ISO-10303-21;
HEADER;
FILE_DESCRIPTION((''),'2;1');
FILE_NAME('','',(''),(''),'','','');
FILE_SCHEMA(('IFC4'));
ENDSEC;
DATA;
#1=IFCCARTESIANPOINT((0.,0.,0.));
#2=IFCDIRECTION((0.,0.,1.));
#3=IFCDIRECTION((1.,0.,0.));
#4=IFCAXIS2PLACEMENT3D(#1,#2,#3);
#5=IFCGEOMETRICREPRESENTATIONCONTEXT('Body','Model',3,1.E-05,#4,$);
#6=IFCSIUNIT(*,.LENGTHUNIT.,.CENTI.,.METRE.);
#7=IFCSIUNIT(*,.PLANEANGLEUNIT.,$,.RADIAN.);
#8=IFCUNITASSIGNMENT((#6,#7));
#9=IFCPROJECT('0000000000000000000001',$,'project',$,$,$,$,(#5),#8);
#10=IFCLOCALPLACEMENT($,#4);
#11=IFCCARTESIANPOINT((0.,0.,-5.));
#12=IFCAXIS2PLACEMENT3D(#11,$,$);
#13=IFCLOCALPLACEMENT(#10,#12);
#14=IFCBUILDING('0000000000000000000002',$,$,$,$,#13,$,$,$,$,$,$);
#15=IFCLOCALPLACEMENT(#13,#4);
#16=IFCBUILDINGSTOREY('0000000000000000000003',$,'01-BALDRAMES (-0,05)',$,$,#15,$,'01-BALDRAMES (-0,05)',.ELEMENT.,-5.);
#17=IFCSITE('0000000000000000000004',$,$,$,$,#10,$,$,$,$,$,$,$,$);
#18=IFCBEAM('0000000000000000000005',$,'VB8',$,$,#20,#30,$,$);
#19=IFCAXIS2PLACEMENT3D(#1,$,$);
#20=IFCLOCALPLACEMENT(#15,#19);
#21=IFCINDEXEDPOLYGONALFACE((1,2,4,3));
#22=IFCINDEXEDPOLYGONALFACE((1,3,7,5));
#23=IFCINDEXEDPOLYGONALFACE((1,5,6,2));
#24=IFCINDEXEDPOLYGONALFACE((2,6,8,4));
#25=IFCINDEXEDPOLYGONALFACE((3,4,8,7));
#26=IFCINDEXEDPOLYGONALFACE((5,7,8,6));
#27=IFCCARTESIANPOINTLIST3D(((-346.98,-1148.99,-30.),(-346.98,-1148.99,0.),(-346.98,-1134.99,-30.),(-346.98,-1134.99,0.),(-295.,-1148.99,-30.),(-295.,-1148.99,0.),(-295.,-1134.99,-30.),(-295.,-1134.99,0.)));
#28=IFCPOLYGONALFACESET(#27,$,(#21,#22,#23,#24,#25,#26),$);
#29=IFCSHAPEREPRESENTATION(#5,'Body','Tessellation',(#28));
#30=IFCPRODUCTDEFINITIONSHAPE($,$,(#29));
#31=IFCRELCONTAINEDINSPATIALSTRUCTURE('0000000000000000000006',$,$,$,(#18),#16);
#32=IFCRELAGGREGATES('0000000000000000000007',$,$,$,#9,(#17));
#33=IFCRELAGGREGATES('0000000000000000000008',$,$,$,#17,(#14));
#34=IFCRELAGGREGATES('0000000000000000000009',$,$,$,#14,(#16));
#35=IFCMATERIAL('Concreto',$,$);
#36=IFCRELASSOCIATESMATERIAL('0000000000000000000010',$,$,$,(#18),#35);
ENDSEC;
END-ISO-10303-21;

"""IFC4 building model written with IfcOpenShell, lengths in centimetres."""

from ifc_helpers import new_model, si_unit, frame, origin_with_axes, origin_2d_with_axis, place, context, project, spatial, rectangle, extrude, material, element, save


model = new_model("IFC4")

# Units and contexts
model_context = context("Model", 3, precision=1e-05, world=origin_with_axes(), identifier="Body")
ifc_project = project(units=[si_unit("LENGTHUNIT", "METRE", prefix="CENTI"), si_unit("PLANEANGLEUNIT", "RADIAN")], contexts=[model_context])

# Site, building, storey
site_placement = place(None, origin_with_axes())
site = spatial("IfcSite", under=ifc_project, at=site_placement)
building_placement = place(site_placement, frame((0.0, 0.0, -5.0)))
building = spatial("IfcBuilding", under=site, at=building_placement)
storey_placement = place(building_placement, origin_with_axes())
storey = spatial("IfcBuildingStorey", under=building, at=storey_placement, Name="01-BALDRAMES (-0,05)", LongName="01-BALDRAMES (-0,05)", CompositionType="ELEMENT", Elevation=-5.0)

# Shared definitions
ifc_material = material(Name="Concreto")

# Beam
beam_1_placement = place(storey_placement, frame((-320.99, -1141.99, 0.0), z_axis=(0.0, 0.0, 1.0), x_axis=(1.0, 0.0, 0.0)))
element("IfcBeam", 1, at=beam_1_placement, inside=storey, material=ifc_material, Name="VB8", context=model_context, shape_type="SolidModel", body=[
    extrude(rectangle(XDim=14.0, YDim=30.0, at=origin_2d_with_axis()), frame((-25.99, 0.0, -15.0), z_axis=(1.0, 0.0, 0.0), x_axis=(0.0, -1.0, 0.0)), (0.0, 0.0, 1.0), 51.98),
])

save(model, "model.ifc")
